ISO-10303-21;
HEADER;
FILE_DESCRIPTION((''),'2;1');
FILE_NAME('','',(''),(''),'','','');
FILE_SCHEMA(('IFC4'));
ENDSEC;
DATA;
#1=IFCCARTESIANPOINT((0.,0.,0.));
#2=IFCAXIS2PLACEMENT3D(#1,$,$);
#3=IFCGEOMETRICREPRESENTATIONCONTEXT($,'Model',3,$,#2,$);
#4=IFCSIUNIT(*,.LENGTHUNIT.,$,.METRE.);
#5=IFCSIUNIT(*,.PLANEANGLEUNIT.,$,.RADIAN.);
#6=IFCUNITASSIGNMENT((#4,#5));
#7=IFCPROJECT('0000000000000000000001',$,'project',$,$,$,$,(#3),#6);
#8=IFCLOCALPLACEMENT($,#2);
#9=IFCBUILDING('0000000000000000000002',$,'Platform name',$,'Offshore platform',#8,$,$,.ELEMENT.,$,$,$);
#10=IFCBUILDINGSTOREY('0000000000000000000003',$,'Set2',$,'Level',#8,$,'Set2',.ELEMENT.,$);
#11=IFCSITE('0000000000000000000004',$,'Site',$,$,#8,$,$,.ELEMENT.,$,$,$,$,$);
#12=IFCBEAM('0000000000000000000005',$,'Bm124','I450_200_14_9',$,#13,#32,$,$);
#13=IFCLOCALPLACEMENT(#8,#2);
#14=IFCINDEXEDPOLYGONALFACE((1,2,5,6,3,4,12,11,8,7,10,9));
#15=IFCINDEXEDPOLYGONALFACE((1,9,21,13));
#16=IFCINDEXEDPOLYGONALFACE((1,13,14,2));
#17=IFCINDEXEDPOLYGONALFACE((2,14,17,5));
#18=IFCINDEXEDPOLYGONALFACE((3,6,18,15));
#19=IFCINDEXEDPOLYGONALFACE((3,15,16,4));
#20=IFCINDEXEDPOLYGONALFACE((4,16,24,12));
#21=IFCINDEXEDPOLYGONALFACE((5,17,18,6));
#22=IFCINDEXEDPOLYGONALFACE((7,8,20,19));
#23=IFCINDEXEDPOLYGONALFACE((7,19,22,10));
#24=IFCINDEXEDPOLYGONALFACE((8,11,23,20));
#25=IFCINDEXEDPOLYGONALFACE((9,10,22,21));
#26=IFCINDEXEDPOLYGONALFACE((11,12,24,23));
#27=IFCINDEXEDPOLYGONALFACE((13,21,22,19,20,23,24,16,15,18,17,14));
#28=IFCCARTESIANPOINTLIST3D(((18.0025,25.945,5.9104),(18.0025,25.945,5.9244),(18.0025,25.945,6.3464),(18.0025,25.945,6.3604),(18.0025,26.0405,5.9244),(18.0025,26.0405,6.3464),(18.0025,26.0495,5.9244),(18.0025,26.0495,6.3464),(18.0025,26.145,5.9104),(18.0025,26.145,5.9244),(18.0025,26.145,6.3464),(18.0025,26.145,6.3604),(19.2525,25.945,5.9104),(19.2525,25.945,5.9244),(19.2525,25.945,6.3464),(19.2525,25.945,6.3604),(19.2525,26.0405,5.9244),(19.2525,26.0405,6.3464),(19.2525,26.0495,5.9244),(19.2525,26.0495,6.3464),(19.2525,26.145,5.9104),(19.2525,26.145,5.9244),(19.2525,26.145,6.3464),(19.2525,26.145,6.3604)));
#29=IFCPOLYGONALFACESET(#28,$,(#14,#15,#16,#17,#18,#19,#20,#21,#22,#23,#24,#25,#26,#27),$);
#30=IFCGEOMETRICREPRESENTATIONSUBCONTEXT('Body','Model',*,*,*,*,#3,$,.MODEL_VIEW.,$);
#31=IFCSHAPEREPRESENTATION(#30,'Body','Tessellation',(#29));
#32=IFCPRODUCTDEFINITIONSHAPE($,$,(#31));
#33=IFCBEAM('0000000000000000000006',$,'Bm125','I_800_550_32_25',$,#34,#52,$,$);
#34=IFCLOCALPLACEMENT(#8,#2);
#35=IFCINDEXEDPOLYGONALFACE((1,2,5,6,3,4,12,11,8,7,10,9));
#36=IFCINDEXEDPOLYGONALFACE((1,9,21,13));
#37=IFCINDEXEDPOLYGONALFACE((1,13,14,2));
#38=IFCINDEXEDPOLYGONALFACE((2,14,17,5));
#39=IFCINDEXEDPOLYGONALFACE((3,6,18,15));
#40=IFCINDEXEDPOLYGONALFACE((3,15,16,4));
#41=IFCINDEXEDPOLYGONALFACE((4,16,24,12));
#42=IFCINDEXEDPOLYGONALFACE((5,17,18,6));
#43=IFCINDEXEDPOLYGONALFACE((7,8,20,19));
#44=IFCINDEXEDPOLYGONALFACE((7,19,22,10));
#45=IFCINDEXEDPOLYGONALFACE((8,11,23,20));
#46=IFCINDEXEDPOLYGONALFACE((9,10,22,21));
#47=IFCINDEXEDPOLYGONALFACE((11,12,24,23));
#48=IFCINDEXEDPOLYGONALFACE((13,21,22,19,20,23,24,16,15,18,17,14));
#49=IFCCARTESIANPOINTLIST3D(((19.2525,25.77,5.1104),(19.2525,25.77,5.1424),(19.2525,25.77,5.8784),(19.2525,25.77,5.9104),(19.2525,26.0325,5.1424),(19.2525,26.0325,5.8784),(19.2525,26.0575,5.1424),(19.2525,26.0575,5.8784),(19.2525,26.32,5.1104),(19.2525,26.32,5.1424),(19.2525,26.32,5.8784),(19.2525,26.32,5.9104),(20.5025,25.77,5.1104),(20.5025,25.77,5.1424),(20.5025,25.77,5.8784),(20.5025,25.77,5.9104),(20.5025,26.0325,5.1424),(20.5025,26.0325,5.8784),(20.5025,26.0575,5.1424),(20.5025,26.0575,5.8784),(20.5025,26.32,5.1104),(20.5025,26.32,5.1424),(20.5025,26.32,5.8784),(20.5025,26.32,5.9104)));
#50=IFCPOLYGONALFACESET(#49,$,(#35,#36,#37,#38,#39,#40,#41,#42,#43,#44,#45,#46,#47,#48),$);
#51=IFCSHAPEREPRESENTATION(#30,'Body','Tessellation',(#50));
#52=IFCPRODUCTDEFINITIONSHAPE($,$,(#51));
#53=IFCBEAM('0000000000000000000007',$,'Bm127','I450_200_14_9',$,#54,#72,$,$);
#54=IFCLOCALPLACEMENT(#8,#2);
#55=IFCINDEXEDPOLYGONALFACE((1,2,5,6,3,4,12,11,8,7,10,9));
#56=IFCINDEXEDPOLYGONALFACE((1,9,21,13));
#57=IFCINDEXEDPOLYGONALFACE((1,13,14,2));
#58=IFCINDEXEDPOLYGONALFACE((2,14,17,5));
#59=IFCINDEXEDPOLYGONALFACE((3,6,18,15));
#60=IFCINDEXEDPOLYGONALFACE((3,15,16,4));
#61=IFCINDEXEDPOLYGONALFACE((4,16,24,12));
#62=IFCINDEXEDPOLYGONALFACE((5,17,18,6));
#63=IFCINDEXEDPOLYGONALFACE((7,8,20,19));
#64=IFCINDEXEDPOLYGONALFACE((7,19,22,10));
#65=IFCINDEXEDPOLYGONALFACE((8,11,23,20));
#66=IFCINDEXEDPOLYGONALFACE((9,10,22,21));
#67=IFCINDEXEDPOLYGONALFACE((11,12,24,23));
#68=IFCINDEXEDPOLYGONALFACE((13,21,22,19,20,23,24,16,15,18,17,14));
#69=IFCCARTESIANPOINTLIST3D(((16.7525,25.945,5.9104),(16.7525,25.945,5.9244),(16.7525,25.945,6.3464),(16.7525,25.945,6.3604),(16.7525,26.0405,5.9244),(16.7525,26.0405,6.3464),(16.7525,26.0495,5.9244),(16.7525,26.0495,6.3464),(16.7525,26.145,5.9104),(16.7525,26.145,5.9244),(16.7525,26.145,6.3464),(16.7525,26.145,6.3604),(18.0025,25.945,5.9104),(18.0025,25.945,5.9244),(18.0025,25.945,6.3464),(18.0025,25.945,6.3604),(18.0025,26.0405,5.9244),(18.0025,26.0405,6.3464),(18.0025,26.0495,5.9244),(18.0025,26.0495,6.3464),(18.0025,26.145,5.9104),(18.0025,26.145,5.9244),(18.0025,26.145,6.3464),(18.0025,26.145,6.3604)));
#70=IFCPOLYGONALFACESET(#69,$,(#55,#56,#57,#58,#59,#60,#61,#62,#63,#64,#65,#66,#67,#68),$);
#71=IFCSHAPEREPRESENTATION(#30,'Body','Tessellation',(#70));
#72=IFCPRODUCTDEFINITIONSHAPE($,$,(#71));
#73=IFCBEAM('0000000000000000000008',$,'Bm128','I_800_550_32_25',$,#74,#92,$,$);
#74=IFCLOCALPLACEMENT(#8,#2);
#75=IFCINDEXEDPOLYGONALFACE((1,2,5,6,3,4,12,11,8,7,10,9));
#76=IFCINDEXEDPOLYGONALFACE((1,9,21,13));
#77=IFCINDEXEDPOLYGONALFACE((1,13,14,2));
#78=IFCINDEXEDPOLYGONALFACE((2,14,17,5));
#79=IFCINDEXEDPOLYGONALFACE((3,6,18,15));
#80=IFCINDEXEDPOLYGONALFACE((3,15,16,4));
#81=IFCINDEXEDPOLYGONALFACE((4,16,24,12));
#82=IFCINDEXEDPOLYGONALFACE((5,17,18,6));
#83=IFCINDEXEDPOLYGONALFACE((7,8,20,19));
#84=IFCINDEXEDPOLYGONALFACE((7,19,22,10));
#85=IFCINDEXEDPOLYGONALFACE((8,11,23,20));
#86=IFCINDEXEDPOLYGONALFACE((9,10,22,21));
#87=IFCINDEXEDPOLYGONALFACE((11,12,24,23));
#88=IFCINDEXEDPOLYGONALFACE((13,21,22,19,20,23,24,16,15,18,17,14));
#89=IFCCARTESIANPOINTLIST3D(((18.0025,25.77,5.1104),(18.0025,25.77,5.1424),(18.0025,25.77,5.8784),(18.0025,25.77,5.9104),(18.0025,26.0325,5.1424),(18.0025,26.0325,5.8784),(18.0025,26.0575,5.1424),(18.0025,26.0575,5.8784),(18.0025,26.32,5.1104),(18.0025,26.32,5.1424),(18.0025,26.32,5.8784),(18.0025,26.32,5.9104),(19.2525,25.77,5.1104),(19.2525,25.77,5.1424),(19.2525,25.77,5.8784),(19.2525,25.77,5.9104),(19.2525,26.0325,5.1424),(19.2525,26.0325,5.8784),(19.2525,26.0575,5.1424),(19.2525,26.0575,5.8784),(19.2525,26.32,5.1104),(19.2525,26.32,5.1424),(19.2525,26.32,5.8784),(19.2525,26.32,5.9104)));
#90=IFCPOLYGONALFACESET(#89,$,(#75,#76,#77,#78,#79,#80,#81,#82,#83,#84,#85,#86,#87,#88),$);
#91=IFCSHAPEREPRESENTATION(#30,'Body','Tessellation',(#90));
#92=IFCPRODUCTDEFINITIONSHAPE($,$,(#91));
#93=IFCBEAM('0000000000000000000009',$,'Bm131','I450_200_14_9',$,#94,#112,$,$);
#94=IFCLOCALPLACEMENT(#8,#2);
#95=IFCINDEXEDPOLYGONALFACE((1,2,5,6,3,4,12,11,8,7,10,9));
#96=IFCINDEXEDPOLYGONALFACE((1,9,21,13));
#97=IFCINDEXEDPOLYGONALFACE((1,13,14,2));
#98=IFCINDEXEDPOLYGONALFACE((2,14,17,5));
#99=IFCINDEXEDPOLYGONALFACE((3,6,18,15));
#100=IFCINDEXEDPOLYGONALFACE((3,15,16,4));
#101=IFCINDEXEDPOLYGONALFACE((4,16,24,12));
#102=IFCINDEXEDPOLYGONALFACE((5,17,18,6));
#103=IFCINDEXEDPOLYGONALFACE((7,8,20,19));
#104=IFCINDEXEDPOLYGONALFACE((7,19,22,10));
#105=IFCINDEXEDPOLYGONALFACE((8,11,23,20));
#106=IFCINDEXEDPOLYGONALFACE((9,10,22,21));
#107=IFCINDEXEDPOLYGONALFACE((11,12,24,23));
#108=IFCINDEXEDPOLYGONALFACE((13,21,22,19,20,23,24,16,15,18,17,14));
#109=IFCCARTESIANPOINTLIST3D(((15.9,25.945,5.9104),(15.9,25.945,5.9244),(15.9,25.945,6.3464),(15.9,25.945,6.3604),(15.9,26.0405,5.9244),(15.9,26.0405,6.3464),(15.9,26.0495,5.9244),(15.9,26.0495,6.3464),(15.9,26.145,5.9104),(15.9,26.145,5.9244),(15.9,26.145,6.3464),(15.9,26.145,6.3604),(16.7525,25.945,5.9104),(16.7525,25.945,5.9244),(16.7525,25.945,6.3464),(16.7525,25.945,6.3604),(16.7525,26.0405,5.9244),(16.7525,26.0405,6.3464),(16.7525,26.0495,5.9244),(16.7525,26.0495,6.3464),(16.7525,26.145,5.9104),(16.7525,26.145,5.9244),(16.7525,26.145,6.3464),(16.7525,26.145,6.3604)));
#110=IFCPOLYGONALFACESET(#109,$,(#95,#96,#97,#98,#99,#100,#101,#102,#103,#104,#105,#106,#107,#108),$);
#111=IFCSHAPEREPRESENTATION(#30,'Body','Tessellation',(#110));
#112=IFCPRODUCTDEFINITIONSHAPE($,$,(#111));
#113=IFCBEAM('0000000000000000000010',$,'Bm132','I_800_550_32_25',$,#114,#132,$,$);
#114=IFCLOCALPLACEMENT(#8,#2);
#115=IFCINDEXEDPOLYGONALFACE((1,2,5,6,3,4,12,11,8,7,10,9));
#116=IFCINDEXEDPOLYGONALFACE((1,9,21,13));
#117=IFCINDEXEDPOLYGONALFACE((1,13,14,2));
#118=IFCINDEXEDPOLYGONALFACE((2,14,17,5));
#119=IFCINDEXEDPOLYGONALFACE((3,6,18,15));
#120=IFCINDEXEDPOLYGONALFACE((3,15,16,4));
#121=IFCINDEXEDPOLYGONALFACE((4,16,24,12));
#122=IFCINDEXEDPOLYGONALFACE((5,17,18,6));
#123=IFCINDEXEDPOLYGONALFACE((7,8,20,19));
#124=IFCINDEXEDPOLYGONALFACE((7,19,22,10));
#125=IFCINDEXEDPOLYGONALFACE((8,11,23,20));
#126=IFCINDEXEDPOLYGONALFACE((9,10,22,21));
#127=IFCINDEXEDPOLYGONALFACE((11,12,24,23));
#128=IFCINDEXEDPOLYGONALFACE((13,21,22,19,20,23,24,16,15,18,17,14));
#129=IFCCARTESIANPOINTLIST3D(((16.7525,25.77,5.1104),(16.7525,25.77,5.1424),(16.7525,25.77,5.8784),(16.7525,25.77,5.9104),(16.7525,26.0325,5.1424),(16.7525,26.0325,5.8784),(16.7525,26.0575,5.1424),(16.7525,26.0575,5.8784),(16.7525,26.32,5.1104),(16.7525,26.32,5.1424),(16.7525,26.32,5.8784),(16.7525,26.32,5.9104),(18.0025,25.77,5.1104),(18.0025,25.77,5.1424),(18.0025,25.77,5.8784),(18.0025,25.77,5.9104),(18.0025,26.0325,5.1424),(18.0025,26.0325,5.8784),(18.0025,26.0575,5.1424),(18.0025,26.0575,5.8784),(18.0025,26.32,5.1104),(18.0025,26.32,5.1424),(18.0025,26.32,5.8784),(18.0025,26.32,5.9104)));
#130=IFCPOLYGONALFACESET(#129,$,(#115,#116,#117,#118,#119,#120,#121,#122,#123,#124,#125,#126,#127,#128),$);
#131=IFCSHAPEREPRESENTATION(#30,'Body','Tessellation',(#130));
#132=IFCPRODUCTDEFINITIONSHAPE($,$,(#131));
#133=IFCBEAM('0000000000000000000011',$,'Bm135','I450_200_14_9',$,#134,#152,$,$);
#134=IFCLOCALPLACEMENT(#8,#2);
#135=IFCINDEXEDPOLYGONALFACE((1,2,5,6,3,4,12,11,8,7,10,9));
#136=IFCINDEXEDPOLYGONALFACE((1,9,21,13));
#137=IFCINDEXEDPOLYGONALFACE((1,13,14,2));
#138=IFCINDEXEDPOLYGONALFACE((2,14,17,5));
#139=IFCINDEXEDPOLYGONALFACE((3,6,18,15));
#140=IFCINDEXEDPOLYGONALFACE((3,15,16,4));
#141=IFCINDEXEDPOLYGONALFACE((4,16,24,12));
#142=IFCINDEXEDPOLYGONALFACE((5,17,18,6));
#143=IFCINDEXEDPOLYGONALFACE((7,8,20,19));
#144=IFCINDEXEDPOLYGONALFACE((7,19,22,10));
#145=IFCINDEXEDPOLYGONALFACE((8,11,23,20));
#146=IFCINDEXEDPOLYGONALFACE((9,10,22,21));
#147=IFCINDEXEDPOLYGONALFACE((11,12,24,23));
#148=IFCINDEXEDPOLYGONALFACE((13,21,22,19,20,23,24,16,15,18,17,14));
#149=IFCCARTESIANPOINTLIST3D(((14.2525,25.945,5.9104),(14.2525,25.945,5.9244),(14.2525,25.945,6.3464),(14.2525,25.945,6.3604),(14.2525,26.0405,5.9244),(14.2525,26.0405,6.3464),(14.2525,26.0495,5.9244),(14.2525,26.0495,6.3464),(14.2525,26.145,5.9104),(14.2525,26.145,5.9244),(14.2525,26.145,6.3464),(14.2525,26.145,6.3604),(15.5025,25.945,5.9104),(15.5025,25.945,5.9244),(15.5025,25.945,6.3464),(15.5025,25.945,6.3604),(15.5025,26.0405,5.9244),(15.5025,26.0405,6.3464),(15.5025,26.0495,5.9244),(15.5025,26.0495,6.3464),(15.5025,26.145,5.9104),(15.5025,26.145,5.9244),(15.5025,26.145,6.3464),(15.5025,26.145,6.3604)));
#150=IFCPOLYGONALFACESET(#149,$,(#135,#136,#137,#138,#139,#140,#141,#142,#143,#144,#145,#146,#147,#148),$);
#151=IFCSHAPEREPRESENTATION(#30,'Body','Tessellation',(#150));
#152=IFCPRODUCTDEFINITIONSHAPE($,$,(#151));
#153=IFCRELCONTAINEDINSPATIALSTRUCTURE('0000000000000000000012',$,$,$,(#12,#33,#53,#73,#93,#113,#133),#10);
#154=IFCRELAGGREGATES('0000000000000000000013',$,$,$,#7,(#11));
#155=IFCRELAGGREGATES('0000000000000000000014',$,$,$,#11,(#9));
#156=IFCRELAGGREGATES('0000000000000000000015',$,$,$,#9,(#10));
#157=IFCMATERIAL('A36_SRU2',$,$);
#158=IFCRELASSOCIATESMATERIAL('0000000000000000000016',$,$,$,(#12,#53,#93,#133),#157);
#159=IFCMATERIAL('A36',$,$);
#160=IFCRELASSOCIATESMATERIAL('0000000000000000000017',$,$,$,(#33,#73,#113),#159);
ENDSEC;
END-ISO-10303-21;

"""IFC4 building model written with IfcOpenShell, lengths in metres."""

from ifc_helpers import new_model, si_unit, frame, origin, origin_2d, place, context, subcontext, project, spatial, i_section, extrude, source, transform, mapped, material, element, save


model = new_model("IFC4")

# Units and contexts
model_context = context("Model", 3, world=origin())
body_context = subcontext(model_context, "Body", "Model", "MODEL_VIEW")
ifc_project = project(units=[si_unit("LENGTHUNIT", "METRE"), si_unit("PLANEANGLEUNIT", "RADIAN")], contexts=[model_context])

# Site, building, storey
placement_1 = place(None, origin())
site = spatial("IfcSite", under=ifc_project, at=placement_1, Name="Site", CompositionType="ELEMENT")
building = spatial("IfcBuilding", under=site, at=placement_1, Name="Platform name", ObjectType="Offshore platform", CompositionType="ELEMENT")
storey = spatial("IfcBuildingStorey", under=building, at=placement_1, Name="Set2", ObjectType="Level", LongName="Set2", CompositionType="ELEMENT")

# Beams
ifc_material_1 = material(Name="A36_SRU2")
ifc_material_2 = material(Name="A36")
shared_shape_1 = source(origin(), body_context, "Body", "SweptSolid", [
    extrude(i_section(OverallWidth=0.2, OverallDepth=0.45, WebThickness=0.009, FlangeThickness=0.014, FilletRadius=0.0, at=origin_2d()), frame((0.0, 0.0, 0.0), z_axis=(-1.0, 0.0, 0.0), x_axis=(0.0, -1.0, 0.0)), (0.0, 0.0, 1.0), 1.25),
])
placement_2 = place(None, origin())
placement_3 = place(placement_2, origin())
placement_4 = place(placement_3, origin())
beam_1_placement = place(placement_4, frame((19.2525, 26.045, 6.1354)))
element("IfcBeam", 1, at=beam_1_placement, inside=storey, material=ifc_material_1, Name="Bm124", Description="I450_200_14_9", context=body_context, shape_type="MappedRepresentation", body=[
    mapped(shared_shape_1, transform((0.0, 0.0, 0.0), scale=1.0)),
])
shared_shape_2 = source(origin(), body_context, "Body", "SweptSolid", [
    extrude(i_section(OverallWidth=0.55, OverallDepth=0.8, WebThickness=0.025, FlangeThickness=0.032, FilletRadius=0.0, at=origin_2d()), frame((0.0, 0.0, 0.0), z_axis=(1.0, 0.0, 0.0), x_axis=(0.0, 1.0, 0.0)), (0.0, 0.0, 1.0), 1.25),
])
placement_5 = place(None, origin())
placement_6 = place(placement_5, origin())
placement_7 = place(placement_6, origin())
beam_2_placement = place(placement_7, frame((19.2525, 26.045, 5.5104)))
element("IfcBeam", 2, at=beam_2_placement, inside=storey, material=ifc_material_2, Name="Bm125", Description="I_800_550_32_25", context=body_context, shape_type="MappedRepresentation", body=[
    mapped(shared_shape_2, transform((0.0, 0.0, 0.0), scale=1.0)),
])
shared_shape_3 = source(origin(), body_context, "Body", "SweptSolid", [
    extrude(i_section(OverallWidth=0.2, OverallDepth=0.45, WebThickness=0.009, FlangeThickness=0.014, FilletRadius=0.0, at=origin_2d()), frame((0.0, 0.0, 0.0), z_axis=(-1.0, 0.0, 0.0), x_axis=(0.0, -1.0, 0.0)), (0.0, 0.0, 1.0), 1.25),
])
placement_8 = place(None, origin())
placement_9 = place(placement_8, origin())
placement_10 = place(placement_9, origin())
beam_3_placement = place(placement_10, frame((18.0025, 26.045, 6.1354)))
element("IfcBeam", 3, at=beam_3_placement, inside=storey, material=ifc_material_1, Name="Bm127", Description="I450_200_14_9", context=body_context, shape_type="MappedRepresentation", body=[
    mapped(shared_shape_3, transform((0.0, 0.0, 0.0), scale=1.0)),
])
shared_shape_4 = source(origin(), body_context, "Body", "SweptSolid", [
    extrude(i_section(OverallWidth=0.55, OverallDepth=0.8, WebThickness=0.025, FlangeThickness=0.032, FilletRadius=0.0, at=origin_2d()), frame((0.0, 0.0, 0.0), z_axis=(1.0, 0.0, 0.0), x_axis=(0.0, 1.0, 0.0)), (0.0, 0.0, 1.0), 1.25),
])
placement_11 = place(None, origin())
placement_12 = place(placement_11, origin())
placement_13 = place(placement_12, origin())
beam_4_placement = place(placement_13, frame((18.0025, 26.045, 5.5104)))
element("IfcBeam", 4, at=beam_4_placement, inside=storey, material=ifc_material_2, Name="Bm128", Description="I_800_550_32_25", context=body_context, shape_type="MappedRepresentation", body=[
    mapped(shared_shape_4, transform((0.0, 0.0, 0.0), scale=1.0)),
])
shared_shape_5 = source(origin(), body_context, "Body", "SweptSolid", [
    extrude(i_section(OverallWidth=0.2, OverallDepth=0.45, WebThickness=0.009, FlangeThickness=0.014, FilletRadius=0.0, at=origin_2d()), frame((0.0, 0.0, 0.0), z_axis=(-1.0, 0.0, 0.0), x_axis=(0.0, -1.0, 0.0)), (0.0, 0.0, 1.0), 0.8525),
])
placement_14 = place(None, origin())
placement_15 = place(placement_14, origin())
placement_16 = place(placement_15, origin())
beam_5_placement = place(placement_16, frame((16.7525, 26.045, 6.1354)))
element("IfcBeam", 5, at=beam_5_placement, inside=storey, material=ifc_material_1, Name="Bm131", Description="I450_200_14_9", context=body_context, shape_type="MappedRepresentation", body=[
    mapped(shared_shape_5, transform((0.0, 0.0, 0.0), scale=1.0)),
])
shared_shape_6 = source(origin(), body_context, "Body", "SweptSolid", [
    extrude(i_section(OverallWidth=0.55, OverallDepth=0.8, WebThickness=0.025, FlangeThickness=0.032, FilletRadius=0.0, at=origin_2d()), frame((0.0, 0.0, 0.0), z_axis=(1.0, 0.0, 0.0), x_axis=(0.0, 1.0, 0.0)), (0.0, 0.0, 1.0), 1.25),
])
placement_17 = place(None, origin())
placement_18 = place(placement_17, origin())
placement_19 = place(placement_18, origin())
beam_6_placement = place(placement_19, frame((16.7525, 26.045, 5.5104)))
element("IfcBeam", 6, at=beam_6_placement, inside=storey, material=ifc_material_2, Name="Bm132", Description="I_800_550_32_25", context=body_context, shape_type="MappedRepresentation", body=[
    mapped(shared_shape_6, transform((0.0, 0.0, 0.0), scale=1.0)),
])
shared_shape_7 = source(origin(), body_context, "Body", "SweptSolid", [
    extrude(i_section(OverallWidth=0.2, OverallDepth=0.45, WebThickness=0.009, FlangeThickness=0.014, FilletRadius=0.0, at=origin_2d()), frame((0.0, 0.0, 0.0), z_axis=(-1.0, 0.0, 0.0), x_axis=(0.0, -1.0, 0.0)), (0.0, 0.0, 1.0), 1.25),
])
placement_20 = place(None, origin())
placement_21 = place(placement_20, origin())
placement_22 = place(placement_21, origin())
beam_7_placement = place(placement_22, frame((15.5025, 26.045, 6.1354)))
element("IfcBeam", 7, at=beam_7_placement, inside=storey, material=ifc_material_1, Name="Bm135", Description="I450_200_14_9", context=body_context, shape_type="MappedRepresentation", body=[
    mapped(shared_shape_7, transform((0.0, 0.0, 0.0), scale=1.0)),
])

save(model, "model.ifc")
